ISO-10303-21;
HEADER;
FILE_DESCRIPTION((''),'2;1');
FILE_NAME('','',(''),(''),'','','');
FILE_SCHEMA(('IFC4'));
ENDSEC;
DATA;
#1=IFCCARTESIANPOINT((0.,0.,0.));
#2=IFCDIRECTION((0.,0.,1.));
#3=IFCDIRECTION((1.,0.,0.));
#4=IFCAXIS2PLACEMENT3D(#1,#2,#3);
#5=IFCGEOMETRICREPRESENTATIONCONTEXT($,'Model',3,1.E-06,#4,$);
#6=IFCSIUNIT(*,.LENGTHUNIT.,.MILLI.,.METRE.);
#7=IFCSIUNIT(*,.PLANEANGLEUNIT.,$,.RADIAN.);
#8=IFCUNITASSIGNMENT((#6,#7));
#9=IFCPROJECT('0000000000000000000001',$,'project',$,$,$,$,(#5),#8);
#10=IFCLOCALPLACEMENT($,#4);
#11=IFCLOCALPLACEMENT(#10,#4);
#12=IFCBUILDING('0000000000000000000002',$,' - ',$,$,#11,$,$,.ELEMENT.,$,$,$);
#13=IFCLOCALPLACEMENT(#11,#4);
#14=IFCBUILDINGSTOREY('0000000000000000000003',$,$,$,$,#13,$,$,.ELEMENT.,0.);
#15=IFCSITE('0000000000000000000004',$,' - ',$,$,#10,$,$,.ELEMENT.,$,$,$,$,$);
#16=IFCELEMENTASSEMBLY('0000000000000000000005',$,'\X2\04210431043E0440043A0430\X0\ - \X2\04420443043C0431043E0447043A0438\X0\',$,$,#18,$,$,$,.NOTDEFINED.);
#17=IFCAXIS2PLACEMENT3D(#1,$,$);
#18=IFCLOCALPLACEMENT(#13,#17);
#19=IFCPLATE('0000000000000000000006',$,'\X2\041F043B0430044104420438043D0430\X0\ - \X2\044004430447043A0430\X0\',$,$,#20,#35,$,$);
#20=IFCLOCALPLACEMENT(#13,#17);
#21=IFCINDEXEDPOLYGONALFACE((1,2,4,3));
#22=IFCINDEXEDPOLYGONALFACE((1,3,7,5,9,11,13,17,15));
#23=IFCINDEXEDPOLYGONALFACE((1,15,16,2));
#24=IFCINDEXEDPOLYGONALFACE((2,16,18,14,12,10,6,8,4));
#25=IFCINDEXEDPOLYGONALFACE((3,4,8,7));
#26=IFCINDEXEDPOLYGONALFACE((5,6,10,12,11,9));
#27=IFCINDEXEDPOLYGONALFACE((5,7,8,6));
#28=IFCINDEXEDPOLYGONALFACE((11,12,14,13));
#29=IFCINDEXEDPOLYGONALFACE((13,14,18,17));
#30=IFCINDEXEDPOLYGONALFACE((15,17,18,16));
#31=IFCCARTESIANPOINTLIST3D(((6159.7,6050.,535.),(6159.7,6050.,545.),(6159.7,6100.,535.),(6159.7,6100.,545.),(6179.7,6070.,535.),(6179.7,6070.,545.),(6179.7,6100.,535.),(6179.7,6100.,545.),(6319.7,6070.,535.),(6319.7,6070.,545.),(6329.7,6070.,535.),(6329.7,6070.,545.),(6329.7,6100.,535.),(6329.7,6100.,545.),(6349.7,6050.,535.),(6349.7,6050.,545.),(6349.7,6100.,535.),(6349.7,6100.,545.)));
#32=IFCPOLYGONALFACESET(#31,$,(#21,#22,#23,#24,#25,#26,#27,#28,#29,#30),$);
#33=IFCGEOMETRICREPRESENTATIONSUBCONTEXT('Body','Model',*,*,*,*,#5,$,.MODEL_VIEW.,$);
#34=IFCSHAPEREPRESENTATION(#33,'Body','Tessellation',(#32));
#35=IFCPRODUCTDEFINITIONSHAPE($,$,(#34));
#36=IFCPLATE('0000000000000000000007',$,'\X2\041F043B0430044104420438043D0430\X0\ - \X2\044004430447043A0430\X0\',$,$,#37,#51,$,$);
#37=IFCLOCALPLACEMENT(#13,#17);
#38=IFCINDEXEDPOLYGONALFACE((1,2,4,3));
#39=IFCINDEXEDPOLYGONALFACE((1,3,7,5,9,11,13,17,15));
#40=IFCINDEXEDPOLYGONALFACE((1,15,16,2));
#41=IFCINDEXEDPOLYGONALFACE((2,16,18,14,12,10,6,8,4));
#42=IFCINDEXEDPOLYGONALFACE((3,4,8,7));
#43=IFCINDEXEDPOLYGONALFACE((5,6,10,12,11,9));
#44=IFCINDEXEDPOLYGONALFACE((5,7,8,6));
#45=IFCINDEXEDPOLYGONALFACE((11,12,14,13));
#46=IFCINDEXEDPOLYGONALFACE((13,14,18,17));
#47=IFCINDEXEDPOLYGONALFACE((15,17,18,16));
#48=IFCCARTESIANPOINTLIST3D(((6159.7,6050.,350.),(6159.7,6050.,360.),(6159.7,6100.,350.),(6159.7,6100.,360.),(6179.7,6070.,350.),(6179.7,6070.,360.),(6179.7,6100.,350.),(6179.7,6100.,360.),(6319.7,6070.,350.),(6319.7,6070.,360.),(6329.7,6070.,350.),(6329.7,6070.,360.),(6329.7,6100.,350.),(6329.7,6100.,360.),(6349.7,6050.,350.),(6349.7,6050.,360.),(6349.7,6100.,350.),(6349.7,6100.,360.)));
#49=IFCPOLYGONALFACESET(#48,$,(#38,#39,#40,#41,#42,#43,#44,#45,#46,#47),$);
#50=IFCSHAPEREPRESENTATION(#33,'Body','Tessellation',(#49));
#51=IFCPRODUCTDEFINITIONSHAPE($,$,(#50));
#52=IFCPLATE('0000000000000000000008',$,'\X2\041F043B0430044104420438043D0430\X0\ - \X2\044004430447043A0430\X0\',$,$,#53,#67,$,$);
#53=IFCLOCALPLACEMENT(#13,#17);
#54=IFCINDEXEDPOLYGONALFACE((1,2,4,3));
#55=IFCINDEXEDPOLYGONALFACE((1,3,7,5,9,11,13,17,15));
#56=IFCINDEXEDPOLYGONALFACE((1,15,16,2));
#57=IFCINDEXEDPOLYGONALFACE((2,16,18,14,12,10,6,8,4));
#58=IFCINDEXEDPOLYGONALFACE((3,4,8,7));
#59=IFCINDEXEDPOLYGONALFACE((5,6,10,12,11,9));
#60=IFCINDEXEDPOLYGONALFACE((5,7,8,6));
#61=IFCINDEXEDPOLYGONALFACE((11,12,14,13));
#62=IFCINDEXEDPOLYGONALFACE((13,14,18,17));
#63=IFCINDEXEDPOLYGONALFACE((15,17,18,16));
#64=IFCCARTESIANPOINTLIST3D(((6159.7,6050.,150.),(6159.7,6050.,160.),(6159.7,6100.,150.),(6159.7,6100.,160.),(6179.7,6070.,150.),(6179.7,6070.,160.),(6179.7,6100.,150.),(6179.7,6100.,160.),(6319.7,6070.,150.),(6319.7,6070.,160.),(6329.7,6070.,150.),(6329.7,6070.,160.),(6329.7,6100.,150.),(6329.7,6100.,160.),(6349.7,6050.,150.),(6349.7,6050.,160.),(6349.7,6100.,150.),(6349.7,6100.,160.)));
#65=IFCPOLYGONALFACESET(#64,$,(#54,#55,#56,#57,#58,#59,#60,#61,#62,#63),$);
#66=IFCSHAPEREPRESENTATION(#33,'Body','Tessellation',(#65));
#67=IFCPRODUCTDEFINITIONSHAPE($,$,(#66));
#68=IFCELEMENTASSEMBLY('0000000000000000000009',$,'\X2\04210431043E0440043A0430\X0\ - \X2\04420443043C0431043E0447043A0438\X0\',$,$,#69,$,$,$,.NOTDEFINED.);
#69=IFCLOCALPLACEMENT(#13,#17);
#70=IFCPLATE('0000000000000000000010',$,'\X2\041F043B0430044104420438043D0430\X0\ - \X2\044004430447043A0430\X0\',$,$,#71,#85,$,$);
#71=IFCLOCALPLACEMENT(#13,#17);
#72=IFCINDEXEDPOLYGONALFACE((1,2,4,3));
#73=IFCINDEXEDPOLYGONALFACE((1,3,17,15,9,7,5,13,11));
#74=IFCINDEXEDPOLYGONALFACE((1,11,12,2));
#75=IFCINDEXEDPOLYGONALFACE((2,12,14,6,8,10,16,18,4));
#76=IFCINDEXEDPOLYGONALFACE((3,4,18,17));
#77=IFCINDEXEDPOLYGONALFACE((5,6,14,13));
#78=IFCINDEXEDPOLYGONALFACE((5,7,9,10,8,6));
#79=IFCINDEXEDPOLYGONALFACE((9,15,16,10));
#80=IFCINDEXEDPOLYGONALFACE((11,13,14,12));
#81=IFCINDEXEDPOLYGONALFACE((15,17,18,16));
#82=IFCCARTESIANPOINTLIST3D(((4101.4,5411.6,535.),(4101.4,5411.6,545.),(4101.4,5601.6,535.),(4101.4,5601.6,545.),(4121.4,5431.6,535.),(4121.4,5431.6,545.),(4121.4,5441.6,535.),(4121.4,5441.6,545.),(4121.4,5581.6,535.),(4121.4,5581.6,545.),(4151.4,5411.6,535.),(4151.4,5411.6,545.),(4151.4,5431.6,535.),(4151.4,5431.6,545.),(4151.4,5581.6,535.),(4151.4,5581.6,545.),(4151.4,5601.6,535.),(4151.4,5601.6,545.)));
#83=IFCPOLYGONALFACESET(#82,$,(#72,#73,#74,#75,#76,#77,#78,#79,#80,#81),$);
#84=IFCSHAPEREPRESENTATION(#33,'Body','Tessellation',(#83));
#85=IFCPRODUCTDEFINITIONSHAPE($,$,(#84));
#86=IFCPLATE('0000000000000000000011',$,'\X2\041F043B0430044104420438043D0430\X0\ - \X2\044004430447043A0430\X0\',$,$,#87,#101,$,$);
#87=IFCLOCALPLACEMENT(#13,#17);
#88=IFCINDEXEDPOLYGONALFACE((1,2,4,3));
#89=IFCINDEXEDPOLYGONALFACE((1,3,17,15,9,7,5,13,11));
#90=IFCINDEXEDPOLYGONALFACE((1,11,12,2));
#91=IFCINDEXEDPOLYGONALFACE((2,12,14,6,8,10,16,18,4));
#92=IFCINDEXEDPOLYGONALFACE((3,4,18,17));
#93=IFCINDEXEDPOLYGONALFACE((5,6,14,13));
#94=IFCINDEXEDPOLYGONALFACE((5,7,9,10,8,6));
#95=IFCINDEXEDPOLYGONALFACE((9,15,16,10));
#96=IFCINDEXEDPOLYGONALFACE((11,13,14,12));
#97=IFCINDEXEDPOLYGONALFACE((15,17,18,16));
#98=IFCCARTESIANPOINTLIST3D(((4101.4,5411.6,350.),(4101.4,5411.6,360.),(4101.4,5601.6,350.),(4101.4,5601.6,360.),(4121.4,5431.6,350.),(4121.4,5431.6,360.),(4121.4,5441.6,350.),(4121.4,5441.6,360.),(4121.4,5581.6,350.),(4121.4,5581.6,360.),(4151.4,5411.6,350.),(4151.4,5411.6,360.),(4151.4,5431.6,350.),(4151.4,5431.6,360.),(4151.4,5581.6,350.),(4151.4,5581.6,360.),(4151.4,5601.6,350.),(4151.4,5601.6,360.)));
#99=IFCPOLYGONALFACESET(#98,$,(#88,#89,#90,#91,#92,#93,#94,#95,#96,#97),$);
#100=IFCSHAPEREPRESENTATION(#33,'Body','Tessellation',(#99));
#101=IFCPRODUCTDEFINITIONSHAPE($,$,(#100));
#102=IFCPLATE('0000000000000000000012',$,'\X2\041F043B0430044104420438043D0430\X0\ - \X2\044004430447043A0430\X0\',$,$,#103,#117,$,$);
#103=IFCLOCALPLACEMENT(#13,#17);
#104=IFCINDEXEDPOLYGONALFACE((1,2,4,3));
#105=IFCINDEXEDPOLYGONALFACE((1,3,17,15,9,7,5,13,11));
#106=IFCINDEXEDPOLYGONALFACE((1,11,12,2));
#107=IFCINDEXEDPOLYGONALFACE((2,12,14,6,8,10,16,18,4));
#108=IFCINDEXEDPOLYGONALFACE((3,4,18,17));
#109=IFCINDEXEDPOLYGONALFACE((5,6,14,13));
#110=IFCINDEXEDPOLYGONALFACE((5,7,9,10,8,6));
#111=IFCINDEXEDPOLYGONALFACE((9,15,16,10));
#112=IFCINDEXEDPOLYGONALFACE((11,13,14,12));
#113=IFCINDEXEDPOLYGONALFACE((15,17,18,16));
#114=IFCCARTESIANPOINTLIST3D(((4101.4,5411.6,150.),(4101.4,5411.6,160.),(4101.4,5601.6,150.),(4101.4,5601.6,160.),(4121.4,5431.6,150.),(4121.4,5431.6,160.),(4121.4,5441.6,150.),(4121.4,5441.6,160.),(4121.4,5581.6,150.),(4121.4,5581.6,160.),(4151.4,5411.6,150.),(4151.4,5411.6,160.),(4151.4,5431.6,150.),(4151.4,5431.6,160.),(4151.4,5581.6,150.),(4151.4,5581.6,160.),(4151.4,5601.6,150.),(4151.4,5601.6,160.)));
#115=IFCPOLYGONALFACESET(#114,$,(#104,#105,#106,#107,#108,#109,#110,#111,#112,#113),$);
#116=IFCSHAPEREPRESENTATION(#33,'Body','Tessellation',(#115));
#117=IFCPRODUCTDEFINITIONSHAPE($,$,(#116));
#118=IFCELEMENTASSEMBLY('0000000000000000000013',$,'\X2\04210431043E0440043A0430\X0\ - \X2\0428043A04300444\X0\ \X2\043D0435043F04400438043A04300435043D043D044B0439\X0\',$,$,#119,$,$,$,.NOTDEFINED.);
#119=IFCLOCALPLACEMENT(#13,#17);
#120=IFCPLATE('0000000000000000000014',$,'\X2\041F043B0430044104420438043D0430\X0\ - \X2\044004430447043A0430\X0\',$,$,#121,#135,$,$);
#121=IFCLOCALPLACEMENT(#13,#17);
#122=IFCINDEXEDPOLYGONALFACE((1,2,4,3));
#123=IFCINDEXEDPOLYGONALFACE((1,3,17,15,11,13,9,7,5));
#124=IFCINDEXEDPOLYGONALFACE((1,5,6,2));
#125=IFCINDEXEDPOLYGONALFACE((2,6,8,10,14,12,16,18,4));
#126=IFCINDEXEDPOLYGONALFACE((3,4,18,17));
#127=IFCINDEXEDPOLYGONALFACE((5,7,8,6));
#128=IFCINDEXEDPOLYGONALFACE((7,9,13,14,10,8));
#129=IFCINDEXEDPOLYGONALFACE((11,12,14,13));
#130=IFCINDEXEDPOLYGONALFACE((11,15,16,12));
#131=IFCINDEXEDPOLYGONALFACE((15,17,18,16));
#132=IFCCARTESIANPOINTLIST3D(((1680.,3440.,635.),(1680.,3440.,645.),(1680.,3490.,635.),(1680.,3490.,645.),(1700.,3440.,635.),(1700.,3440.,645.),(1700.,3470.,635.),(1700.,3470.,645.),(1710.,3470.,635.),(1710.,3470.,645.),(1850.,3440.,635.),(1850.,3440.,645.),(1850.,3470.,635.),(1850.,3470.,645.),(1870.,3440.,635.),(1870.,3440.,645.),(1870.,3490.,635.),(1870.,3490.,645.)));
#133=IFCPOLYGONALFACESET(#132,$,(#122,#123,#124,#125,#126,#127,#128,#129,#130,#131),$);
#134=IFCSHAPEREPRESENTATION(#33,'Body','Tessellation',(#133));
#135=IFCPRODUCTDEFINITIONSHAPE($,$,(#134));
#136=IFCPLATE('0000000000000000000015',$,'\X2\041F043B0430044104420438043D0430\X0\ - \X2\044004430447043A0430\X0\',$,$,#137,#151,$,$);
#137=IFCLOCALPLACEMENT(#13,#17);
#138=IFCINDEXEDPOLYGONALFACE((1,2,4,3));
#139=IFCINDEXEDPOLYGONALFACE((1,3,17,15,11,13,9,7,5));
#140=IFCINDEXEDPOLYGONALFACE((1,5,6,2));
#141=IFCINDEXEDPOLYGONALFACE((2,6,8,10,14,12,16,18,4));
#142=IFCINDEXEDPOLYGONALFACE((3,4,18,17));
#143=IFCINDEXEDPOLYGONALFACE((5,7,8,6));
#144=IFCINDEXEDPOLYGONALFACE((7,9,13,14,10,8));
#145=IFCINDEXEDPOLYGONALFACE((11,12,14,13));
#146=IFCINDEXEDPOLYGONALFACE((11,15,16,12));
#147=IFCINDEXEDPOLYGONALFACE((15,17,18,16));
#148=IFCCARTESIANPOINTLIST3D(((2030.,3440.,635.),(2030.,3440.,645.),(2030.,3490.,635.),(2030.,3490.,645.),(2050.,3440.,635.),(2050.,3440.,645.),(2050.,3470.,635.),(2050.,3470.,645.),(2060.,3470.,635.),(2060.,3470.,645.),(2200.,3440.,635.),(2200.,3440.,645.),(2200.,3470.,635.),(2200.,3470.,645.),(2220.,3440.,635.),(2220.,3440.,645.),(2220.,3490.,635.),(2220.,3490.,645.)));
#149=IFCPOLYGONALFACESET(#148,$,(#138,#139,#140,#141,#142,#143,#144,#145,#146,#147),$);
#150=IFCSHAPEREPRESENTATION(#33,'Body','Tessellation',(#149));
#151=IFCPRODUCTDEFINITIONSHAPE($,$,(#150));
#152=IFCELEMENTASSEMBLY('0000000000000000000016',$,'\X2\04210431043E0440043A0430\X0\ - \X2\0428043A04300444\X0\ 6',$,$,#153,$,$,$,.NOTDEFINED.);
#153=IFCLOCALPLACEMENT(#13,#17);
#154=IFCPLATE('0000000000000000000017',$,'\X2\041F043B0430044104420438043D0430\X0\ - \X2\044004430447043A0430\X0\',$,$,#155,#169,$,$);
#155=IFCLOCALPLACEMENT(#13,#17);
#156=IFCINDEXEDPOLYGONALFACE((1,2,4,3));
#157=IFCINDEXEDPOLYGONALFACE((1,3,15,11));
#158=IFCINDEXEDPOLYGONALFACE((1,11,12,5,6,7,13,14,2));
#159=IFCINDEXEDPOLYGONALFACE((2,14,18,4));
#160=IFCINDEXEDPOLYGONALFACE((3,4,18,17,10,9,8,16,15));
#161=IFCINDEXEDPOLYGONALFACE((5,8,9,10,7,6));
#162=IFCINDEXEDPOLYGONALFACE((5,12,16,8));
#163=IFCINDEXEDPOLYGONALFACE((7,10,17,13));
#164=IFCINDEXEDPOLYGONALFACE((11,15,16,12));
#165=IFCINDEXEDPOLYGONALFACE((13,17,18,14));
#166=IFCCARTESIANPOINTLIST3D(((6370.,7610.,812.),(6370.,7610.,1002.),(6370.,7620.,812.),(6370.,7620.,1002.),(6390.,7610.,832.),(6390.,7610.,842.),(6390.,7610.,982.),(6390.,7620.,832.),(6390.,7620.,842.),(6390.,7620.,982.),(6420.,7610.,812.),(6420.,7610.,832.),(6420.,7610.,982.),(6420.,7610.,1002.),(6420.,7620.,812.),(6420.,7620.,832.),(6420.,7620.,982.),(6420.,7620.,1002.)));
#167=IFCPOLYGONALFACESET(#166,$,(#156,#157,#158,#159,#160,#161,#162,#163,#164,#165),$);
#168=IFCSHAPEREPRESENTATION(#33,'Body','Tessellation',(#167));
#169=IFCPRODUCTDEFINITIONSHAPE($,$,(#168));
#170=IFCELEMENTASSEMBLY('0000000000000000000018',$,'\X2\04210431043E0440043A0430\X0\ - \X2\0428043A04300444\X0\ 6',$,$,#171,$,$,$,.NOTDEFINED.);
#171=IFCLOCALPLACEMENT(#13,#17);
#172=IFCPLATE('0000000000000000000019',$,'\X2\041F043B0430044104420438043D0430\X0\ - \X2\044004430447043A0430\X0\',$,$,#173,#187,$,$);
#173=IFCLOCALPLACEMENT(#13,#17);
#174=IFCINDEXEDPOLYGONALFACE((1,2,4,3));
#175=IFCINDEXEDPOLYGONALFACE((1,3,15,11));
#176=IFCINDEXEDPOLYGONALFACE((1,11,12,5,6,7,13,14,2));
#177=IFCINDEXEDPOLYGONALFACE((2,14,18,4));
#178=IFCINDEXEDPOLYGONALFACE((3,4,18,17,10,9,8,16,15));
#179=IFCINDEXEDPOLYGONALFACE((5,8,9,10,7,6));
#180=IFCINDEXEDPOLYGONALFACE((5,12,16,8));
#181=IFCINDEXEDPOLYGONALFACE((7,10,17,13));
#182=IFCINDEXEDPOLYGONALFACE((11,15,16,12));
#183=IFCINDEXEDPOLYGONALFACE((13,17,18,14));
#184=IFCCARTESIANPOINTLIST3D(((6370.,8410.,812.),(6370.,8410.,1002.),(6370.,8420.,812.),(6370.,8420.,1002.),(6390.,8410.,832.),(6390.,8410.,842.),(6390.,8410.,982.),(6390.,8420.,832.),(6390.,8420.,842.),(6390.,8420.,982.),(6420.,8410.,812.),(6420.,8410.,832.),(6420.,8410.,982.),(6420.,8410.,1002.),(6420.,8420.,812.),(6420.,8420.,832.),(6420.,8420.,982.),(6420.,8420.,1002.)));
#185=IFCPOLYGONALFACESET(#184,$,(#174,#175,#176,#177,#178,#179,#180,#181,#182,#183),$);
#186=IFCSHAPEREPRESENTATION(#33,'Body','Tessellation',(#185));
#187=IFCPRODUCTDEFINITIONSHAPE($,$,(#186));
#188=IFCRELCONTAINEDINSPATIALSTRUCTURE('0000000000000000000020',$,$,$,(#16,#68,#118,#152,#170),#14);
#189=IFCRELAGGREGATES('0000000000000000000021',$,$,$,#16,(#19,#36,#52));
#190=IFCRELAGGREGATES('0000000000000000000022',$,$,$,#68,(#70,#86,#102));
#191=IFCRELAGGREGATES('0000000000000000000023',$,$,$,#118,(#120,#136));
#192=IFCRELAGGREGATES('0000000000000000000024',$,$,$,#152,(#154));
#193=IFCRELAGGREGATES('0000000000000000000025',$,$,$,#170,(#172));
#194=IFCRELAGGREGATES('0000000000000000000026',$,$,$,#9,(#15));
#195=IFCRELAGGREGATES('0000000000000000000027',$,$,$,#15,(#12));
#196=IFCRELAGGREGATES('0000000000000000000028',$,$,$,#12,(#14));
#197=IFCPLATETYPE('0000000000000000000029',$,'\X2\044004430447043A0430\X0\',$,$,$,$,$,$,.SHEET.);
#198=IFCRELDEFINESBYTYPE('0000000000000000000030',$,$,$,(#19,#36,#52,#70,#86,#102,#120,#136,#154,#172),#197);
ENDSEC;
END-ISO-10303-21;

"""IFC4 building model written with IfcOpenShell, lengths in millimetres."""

from ifc_helpers import new_model, si_unit, frame, origin_with_axes, place, context, subcontext, project, spatial, line, indexed_curve, outline, extrude, source, transform, mapped, type_object, element, aggregate, save


model = new_model("IFC4")

# Units and contexts
model_context = context("Model", 3, precision=1e-06, world=origin_with_axes())
body_context = subcontext(model_context, "Body", "Model", "MODEL_VIEW")
ifc_project = project(units=[si_unit("LENGTHUNIT", "METRE", prefix="MILLI"), si_unit("PLANEANGLEUNIT", "RADIAN")], contexts=[model_context])

# Site, building, storey
site_placement = place(None, origin_with_axes())
site = spatial("IfcSite", under=ifc_project, at=site_placement, Name=" - ", CompositionType="ELEMENT")
building_placement = place(site_placement, origin_with_axes())
building = spatial("IfcBuilding", under=site, at=building_placement, Name=" - ", CompositionType="ELEMENT")
storey_placement = place(building_placement, origin_with_axes())
storey = spatial("IfcBuildingStorey", under=building, at=storey_placement, CompositionType="ELEMENT", Elevation=0.0)

# Element assemblies, plates
plate_type = type_object("IfcPlateType", Name="ручка", PredefinedType="SHEET")
shared_shape_1 = source(origin_with_axes(), body_context, "Body", "SweptSolid", [
    extrude(outline(indexed_curve([(-95.0, -25.0), (-75.0, -25.0), (-75.0, 5.0), (-65.0, 5.0), (75.0, 5.0), (75.0, -25.0), (95.0, -25.0), (95.0, 25.0), (-95.0, 25.0)], segments=[line(1, 2), line(2, 3), line(3, 4), line(4, 5), line(5, 6), line(6, 7), line(7, 8), line(8, 9), line(9, 1)])), origin_with_axes(), (0.0, 0.0, 1.0), 10.0),
])
assembly_1_placement = place(storey_placement, frame((6054.7, 6100.0, 0.0), z_axis=(0.0, 0.0, 1.0), x_axis=(1.0, 0.0, 0.0)))
assembly_1 = element("IfcElementAssembly", 1, at=assembly_1_placement, inside=storey, Name="Сборка - тумбочки", PredefinedType="NOTDEFINED")
plate_1_placement = place(assembly_1_placement, frame((200.0, -25.0, 535.0), z_axis=(0.0, 0.0, 1.0), x_axis=(-1.0, 0.0, 0.0)))
plate_1 = element("IfcPlate", 2, at=plate_1_placement, type_object=plate_type, Name="Пластина - ручка", context=body_context, shape_type="MappedRepresentation", body=[
    mapped(shared_shape_1, transform((0.0, 0.0, 0.0), x_axis=(1.0, 0.0, 0.0), y_axis=(0.0, 1.0, 0.0), z_axis=(0.0, 0.0, 1.0), scale=1.0)),
])
plate_2_placement = place(assembly_1_placement, frame((200.0, -25.0, 350.0), z_axis=(0.0, 0.0, 1.0), x_axis=(-1.0, 0.0, 0.0)))
plate_2 = element("IfcPlate", 3, at=plate_2_placement, type_object=plate_type, Name="Пластина - ручка", context=body_context, shape_type="MappedRepresentation", body=[
    mapped(shared_shape_1, transform((0.0, 0.0, 0.0), x_axis=(1.0, 0.0, 0.0), y_axis=(0.0, 1.0, 0.0), z_axis=(0.0, 0.0, 1.0), scale=1.0)),
])
plate_3_placement = place(assembly_1_placement, frame((200.0, -25.0, 150.0), z_axis=(0.0, 0.0, 1.0), x_axis=(-1.0, 0.0, 0.0)))
plate_3 = element("IfcPlate", 4, at=plate_3_placement, type_object=plate_type, Name="Пластина - ручка", context=body_context, shape_type="MappedRepresentation", body=[
    mapped(shared_shape_1, transform((0.0, 0.0, 0.0), x_axis=(1.0, 0.0, 0.0), y_axis=(0.0, 1.0, 0.0), z_axis=(0.0, 0.0, 1.0), scale=1.0)),
])
aggregate(assembly_1, [plate_1, plate_2, plate_3])
assembly_2_placement = place(storey_placement, frame((4151.4, 5706.6, 0.0), z_axis=(0.0, 0.0, 1.0), x_axis=(0.0, -1.0, 0.0)))
assembly_2 = element("IfcElementAssembly", 5, at=assembly_2_placement, inside=storey, Name="Сборка - тумбочки", PredefinedType="NOTDEFINED")
plate_4_placement = place(assembly_2_placement, frame((200.0, -25.0, 535.0), z_axis=(0.0, 0.0, 1.0), x_axis=(-1.0, 0.0, 0.0)))
plate_4 = element("IfcPlate", 6, at=plate_4_placement, type_object=plate_type, Name="Пластина - ручка", context=body_context, shape_type="MappedRepresentation", body=[
    mapped(shared_shape_1, transform((0.0, 0.0, 0.0), x_axis=(1.0, 0.0, 0.0), y_axis=(0.0, 1.0, 0.0), z_axis=(0.0, 0.0, 1.0), scale=1.0)),
])
plate_5_placement = place(assembly_2_placement, frame((200.0, -25.0, 350.0), z_axis=(0.0, 0.0, 1.0), x_axis=(-1.0, 0.0, 0.0)))
plate_5 = element("IfcPlate", 7, at=plate_5_placement, type_object=plate_type, Name="Пластина - ручка", context=body_context, shape_type="MappedRepresentation", body=[
    mapped(shared_shape_1, transform((0.0, 0.0, 0.0), x_axis=(1.0, 0.0, 0.0), y_axis=(0.0, 1.0, 0.0), z_axis=(0.0, 0.0, 1.0), scale=1.0)),
])
plate_6_placement = place(assembly_2_placement, frame((200.0, -25.0, 150.0), z_axis=(0.0, 0.0, 1.0), x_axis=(-1.0, 0.0, 0.0)))
plate_6 = element("IfcPlate", 8, at=plate_6_placement, type_object=plate_type, Name="Пластина - ручка", context=body_context, shape_type="MappedRepresentation", body=[
    mapped(shared_shape_1, transform((0.0, 0.0, 0.0), x_axis=(1.0, 0.0, 0.0), y_axis=(0.0, 1.0, 0.0), z_axis=(0.0, 0.0, 1.0), scale=1.0)),
])
aggregate(assembly_2, [plate_4, plate_5, plate_6])
assembly_3_placement = place(storey_placement, frame((2400.0, 3440.0, 0.0), z_axis=(0.0, 0.0, 1.0), x_axis=(-1.0, 0.0, 0.0)))
assembly_3 = element("IfcElementAssembly", 9, at=assembly_3_placement, inside=storey, Name="Сборка - Шкаф неприкаенный", PredefinedType="NOTDEFINED")
plate_7_placement = place(assembly_3_placement, frame((625.0, -25.0, 635.0), z_axis=(0.0, 0.0, 1.0), x_axis=(-1.0, 0.0, 0.0)))
plate_7 = element("IfcPlate", 10, at=plate_7_placement, type_object=plate_type, Name="Пластина - ручка", context=body_context, shape_type="MappedRepresentation", body=[
    mapped(shared_shape_1, transform((0.0, 0.0, 0.0), x_axis=(1.0, 0.0, 0.0), y_axis=(0.0, 1.0, 0.0), z_axis=(0.0, 0.0, 1.0), scale=1.0)),
])
plate_8_placement = place(assembly_3_placement, frame((275.0, -25.0, 635.0), z_axis=(0.0, 0.0, 1.0), x_axis=(-1.0, 0.0, 0.0)))
plate_8 = element("IfcPlate", 11, at=plate_8_placement, type_object=plate_type, Name="Пластина - ручка", context=body_context, shape_type="MappedRepresentation", body=[
    mapped(shared_shape_1, transform((0.0, 0.0, 0.0), x_axis=(1.0, 0.0, 0.0), y_axis=(0.0, 1.0, 0.0), z_axis=(0.0, 0.0, 1.0), scale=1.0)),
])
aggregate(assembly_3, [plate_7, plate_8])

# Element assemblies, plates
assembly_4_placement = place(storey_placement, frame((6420.0, 8050.0, 2.0), z_axis=(0.0, 0.0, 1.0), x_axis=(0.0, -1.0, 0.0)))
assembly_4 = element("IfcElementAssembly", 12, at=assembly_4_placement, inside=storey, Name="Сборка - Шкаф 6", PredefinedType="NOTDEFINED")
shared_shape_2 = source(origin_with_axes(), body_context, "Body", "SweptSolid", [
    extrude(outline(indexed_curve([(-95.0, -25.0), (-75.0, -25.0), (-75.0, 5.0), (-65.0, 5.0), (75.0, 5.0), (75.0, -25.0), (95.0, -25.0), (95.0, 25.0), (-95.0, 25.0)], segments=[line(1, 2), line(2, 3), line(3, 4), line(4, 5), line(5, 6), line(6, 7), line(7, 8), line(8, 9), line(9, 1)])), origin_with_axes(), (0.0, 0.0, 1.0), 10.0),
])
plate_9_placement = place(assembly_4_placement, frame((430.0, -25.0, 905.0), z_axis=(1.0, 0.0, 0.0), x_axis=(0.0, 0.0, 1.0)))
plate_9 = element("IfcPlate", 13, at=plate_9_placement, type_object=plate_type, Name="Пластина - ручка", context=body_context, shape_type="MappedRepresentation", body=[
    mapped(shared_shape_2, transform((0.0, 0.0, 0.0), x_axis=(1.0, 0.0, 0.0), y_axis=(0.0, 1.0, 0.0), z_axis=(0.0, 0.0, 1.0), scale=1.0)),
])
assembly_5_placement = place(storey_placement, frame((6420.0, 8850.0, 2.0), z_axis=(0.0, 0.0, 1.0), x_axis=(0.0, -1.0, 0.0)))
assembly_5 = element("IfcElementAssembly", 14, at=assembly_5_placement, inside=storey, Name="Сборка - Шкаф 6", PredefinedType="NOTDEFINED")
plate_10_placement = place(assembly_5_placement, frame((430.0, -25.0, 905.0), z_axis=(1.0, 0.0, 0.0), x_axis=(0.0, 0.0, 1.0)))
plate_10 = element("IfcPlate", 15, at=plate_10_placement, type_object=plate_type, Name="Пластина - ручка", context=body_context, shape_type="MappedRepresentation", body=[
    mapped(shared_shape_2, transform((0.0, 0.0, 0.0), x_axis=(1.0, 0.0, 0.0), y_axis=(0.0, 1.0, 0.0), z_axis=(0.0, 0.0, 1.0), scale=1.0)),
])

aggregate(assembly_4, [plate_9])
aggregate(assembly_5, [plate_10])

save(model, "model.ifc")
